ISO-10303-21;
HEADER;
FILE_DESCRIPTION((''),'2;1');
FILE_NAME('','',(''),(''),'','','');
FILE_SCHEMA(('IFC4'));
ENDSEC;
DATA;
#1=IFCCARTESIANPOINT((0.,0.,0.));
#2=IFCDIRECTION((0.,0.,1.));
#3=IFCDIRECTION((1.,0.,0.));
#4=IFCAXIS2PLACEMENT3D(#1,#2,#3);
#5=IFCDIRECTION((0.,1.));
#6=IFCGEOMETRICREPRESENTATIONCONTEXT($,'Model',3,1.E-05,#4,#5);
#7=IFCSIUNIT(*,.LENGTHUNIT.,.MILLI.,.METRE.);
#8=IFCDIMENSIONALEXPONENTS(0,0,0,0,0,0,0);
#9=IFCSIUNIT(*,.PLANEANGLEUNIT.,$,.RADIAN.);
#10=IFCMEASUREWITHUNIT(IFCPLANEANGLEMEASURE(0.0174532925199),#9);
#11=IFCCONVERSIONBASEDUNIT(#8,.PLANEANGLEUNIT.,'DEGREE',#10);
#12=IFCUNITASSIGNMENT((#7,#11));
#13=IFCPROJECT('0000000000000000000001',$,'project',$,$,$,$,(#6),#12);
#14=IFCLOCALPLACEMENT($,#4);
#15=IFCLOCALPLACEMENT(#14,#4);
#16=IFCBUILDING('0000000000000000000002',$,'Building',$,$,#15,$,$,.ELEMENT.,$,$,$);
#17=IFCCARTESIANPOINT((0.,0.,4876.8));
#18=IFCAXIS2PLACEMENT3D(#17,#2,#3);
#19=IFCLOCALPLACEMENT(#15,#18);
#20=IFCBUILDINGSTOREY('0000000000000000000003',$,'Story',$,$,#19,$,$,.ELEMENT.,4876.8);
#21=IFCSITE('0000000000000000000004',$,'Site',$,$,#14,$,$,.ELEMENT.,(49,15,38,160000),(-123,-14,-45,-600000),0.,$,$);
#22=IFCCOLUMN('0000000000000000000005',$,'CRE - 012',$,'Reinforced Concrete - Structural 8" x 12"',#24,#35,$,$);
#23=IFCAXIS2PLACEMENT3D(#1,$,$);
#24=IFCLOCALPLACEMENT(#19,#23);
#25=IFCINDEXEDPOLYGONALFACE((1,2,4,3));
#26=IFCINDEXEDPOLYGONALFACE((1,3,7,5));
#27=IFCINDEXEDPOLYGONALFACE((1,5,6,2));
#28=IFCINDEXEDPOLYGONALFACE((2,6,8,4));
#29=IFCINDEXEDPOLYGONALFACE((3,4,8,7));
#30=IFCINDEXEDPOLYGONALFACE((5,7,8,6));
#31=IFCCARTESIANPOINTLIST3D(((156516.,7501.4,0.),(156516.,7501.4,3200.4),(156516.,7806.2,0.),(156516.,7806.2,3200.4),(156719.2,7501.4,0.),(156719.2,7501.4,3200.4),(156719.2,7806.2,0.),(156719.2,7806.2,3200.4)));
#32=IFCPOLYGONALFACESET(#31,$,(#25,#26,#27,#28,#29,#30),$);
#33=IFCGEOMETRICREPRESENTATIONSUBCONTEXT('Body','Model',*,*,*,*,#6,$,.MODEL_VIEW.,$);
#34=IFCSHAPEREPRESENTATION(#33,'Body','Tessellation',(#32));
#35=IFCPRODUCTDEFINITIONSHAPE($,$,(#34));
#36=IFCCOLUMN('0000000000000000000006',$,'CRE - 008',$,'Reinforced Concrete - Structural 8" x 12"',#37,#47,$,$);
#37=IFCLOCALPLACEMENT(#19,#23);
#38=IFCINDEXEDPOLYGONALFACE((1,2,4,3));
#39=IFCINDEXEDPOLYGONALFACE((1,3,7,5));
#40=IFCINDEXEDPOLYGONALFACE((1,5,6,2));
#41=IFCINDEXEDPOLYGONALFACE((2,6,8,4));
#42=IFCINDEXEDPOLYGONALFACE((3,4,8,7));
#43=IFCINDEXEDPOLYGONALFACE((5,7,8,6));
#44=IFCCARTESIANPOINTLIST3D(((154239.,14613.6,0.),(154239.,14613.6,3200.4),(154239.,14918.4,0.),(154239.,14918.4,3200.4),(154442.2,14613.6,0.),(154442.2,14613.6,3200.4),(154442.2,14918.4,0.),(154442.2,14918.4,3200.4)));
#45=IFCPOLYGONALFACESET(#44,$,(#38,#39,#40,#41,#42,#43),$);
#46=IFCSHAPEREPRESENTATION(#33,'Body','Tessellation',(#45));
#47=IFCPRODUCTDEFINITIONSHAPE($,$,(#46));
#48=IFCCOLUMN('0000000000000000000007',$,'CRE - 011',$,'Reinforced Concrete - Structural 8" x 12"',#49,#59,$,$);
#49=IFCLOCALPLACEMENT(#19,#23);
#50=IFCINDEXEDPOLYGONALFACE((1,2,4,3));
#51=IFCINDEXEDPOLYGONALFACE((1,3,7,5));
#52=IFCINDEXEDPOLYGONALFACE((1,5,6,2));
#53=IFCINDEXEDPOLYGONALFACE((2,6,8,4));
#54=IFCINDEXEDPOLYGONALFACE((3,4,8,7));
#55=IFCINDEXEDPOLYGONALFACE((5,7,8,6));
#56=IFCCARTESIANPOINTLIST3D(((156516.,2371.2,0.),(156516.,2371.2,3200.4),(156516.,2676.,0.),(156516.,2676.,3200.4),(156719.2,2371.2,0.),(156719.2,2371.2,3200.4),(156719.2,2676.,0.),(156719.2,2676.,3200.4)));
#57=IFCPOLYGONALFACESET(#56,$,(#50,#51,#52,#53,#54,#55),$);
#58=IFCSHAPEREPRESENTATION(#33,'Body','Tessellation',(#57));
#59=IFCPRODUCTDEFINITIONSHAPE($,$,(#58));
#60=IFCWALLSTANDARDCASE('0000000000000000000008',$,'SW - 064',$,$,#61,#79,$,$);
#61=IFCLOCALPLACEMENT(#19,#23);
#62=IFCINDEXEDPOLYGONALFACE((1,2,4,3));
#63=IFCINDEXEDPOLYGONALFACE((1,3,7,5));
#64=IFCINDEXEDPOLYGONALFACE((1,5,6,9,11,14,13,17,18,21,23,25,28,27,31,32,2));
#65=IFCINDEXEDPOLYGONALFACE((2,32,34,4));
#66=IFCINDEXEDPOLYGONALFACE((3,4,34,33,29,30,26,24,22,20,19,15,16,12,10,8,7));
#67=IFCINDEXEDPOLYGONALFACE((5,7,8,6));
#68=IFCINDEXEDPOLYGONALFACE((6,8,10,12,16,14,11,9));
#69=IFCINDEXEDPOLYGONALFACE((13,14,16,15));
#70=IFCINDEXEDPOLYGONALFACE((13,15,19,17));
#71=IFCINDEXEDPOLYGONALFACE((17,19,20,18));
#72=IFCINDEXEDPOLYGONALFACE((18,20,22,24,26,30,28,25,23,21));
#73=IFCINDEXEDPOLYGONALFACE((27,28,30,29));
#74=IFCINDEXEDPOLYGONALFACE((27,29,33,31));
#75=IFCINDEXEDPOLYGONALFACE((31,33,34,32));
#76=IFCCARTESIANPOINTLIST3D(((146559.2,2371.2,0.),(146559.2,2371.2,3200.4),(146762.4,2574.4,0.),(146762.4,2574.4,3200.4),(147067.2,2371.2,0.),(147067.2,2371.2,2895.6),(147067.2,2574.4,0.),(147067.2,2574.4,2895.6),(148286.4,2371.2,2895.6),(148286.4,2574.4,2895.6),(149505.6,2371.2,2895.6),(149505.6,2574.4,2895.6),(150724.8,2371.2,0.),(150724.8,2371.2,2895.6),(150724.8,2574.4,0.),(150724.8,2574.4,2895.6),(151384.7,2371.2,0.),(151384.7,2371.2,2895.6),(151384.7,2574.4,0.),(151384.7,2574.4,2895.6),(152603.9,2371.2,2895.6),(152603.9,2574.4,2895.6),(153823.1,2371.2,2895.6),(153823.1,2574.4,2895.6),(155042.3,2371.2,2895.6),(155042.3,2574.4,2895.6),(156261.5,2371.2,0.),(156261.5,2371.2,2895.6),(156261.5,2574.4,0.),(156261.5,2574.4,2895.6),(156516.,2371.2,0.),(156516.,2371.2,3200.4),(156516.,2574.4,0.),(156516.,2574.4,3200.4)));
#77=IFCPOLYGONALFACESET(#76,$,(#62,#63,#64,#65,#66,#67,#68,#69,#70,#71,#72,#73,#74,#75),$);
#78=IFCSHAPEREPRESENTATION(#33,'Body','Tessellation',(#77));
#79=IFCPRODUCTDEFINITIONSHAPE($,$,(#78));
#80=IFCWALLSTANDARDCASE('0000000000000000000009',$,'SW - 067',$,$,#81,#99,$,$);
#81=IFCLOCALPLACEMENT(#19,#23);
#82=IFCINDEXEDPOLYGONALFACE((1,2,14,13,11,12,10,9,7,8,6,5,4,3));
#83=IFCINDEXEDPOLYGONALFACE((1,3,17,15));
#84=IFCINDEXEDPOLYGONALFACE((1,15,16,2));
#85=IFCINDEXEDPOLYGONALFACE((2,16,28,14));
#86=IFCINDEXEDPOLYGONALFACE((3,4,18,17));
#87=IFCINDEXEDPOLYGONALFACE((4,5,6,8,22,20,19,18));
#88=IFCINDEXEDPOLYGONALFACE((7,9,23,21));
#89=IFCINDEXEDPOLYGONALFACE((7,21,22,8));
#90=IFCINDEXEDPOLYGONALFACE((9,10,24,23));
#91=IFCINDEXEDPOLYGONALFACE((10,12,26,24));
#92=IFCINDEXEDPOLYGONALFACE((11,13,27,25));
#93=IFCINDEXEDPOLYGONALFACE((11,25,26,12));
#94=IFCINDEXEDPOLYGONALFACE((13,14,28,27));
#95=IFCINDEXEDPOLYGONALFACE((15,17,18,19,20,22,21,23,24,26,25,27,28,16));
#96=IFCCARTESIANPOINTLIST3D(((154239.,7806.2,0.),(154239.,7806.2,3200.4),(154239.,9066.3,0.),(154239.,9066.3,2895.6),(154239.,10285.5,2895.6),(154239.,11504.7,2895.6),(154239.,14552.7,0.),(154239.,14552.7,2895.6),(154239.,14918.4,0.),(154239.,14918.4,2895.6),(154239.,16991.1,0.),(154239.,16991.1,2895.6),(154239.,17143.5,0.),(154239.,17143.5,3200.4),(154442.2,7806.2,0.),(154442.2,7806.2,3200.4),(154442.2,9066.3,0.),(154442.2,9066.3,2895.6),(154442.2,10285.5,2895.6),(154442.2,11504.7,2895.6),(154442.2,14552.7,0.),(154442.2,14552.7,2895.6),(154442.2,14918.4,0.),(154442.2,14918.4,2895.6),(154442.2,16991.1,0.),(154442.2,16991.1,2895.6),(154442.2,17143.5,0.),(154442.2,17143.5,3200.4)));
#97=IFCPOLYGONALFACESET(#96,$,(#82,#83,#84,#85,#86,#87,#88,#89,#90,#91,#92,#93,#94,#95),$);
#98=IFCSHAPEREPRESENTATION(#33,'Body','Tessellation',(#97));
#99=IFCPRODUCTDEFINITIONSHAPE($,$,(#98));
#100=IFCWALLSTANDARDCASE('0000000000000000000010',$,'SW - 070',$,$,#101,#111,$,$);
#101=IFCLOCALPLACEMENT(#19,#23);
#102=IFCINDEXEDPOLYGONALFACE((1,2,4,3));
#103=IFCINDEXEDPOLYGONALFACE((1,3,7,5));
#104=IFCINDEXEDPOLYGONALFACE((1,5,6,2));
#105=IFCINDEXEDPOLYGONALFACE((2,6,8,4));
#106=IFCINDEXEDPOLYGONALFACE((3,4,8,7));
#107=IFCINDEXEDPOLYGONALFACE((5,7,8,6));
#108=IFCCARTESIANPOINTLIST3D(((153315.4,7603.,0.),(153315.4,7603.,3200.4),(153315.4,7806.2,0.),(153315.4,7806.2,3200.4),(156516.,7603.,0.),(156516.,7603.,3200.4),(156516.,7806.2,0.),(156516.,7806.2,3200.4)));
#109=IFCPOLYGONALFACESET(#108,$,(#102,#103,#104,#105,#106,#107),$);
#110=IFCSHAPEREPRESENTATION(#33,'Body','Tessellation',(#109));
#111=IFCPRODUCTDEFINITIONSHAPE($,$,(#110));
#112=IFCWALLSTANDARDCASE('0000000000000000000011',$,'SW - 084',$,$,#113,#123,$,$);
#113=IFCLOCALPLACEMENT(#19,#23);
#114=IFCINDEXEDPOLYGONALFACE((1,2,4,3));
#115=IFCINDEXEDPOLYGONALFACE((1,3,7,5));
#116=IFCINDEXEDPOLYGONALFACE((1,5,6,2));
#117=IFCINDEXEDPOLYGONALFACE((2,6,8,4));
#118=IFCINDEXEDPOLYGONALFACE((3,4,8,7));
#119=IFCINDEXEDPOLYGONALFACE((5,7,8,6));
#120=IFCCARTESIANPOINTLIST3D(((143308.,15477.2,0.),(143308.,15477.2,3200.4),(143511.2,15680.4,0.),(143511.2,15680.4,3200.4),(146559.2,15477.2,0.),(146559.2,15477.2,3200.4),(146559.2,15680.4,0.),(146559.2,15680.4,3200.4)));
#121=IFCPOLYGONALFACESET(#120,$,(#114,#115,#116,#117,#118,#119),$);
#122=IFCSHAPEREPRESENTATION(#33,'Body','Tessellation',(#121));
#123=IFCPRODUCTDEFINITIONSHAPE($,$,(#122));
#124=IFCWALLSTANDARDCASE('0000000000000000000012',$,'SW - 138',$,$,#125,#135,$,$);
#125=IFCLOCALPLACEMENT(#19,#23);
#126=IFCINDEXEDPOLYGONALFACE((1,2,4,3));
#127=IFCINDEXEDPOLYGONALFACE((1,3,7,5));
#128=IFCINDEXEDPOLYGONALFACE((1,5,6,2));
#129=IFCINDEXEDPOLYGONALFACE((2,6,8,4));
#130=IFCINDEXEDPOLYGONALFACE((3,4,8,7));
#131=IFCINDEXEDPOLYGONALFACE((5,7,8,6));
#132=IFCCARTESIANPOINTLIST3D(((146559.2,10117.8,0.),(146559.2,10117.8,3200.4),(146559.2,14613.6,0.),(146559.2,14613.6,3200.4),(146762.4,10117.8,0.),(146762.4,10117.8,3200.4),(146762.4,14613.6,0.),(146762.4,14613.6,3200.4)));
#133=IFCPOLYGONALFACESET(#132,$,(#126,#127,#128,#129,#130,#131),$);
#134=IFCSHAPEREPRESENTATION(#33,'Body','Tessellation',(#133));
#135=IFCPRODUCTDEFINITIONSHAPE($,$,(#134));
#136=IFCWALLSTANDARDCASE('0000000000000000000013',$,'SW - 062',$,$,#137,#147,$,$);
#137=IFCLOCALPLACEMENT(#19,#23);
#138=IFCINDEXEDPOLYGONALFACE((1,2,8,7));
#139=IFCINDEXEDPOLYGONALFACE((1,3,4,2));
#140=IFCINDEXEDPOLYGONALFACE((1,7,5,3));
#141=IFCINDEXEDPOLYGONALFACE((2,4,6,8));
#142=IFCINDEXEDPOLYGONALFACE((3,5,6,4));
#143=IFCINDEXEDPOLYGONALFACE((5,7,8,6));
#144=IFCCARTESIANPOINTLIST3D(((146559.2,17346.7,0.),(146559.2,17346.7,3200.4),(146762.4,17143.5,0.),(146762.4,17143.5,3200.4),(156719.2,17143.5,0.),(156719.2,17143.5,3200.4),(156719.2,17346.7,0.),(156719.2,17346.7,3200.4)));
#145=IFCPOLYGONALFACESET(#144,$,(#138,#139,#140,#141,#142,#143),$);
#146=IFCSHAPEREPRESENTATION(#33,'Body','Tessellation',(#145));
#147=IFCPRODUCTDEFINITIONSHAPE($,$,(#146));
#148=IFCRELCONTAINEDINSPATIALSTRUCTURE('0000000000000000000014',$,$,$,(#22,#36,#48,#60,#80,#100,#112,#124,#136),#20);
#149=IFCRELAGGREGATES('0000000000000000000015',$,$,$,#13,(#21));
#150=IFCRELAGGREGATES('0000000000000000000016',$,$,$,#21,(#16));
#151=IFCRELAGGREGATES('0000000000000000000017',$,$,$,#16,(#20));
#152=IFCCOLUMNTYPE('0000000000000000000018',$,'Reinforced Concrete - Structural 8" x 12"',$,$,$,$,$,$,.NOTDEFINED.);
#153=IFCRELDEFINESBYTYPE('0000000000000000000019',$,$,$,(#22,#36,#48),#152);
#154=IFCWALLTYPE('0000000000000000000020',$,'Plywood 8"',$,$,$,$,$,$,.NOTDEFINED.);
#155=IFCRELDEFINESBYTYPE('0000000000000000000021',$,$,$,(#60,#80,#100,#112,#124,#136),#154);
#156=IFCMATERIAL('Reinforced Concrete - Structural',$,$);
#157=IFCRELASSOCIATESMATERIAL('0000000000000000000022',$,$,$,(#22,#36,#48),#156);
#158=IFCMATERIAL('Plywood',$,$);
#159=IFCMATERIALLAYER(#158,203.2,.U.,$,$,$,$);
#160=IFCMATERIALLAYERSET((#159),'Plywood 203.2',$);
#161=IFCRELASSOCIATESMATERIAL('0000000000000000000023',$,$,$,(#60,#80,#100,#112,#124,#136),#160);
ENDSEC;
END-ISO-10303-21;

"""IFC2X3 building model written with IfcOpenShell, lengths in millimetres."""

from ifc_helpers import new_model, entity, si_unit, converted_unit, direction, frame, origin_with_axes, origin_2d_with_axis, place, context, subcontext, project, spatial, polyline, rectangle, outline, extrude, material, layer, layer_set, layer_usage, type_object, element, save


model = new_model("IFC2X3")

# Units and contexts
model_context = context("Model", 3, precision=1e-05, world=origin_with_axes(), true_north=direction((0.0, 1.0)))
body_context = subcontext(model_context, "Body", "Model", "MODEL_VIEW")
ifc_project = project(units=[si_unit("LENGTHUNIT", "METRE", prefix="MILLI"), converted_unit("PLANEANGLEUNIT", "DEGREE", entity("IfcPlaneAngleMeasure", 0.0174532925199), si_unit("PLANEANGLEUNIT", "RADIAN"), dimensions=[0, 0, 0, 0, 0, 0, 0])], contexts=[model_context])

# Site, building, storey
site_placement = place(None, origin_with_axes())
site = spatial("IfcSite", under=ifc_project, at=site_placement, Name="Site", CompositionType="ELEMENT", RefLatitude=(49, 15, 38, 160000), RefLongitude=(-123, -14, -45, -600000), RefElevation=0.0)
building_placement = place(site_placement, origin_with_axes())
building = spatial("IfcBuilding", under=site, at=building_placement, Name="Building", CompositionType="ELEMENT")
storey_placement = place(building_placement, frame((0.0, 0.0, 4876.8), z_axis=(0.0, 0.0, 1.0), x_axis=(1.0, 0.0, 0.0)))
storey = spatial("IfcBuildingStorey", under=building, at=storey_placement, Name="Story", CompositionType="ELEMENT", Elevation=4876.8)

# Columns
ifc_material_1 = material(Name="Reinforced Concrete - Structural")
column_type = type_object("IfcColumnType", Name="Reinforced Concrete - Structural 8\" x 12\"", PredefinedType="NOTDEFINED")
for number, where, z_axis, x_axis, name in (
    (1, (156617.6, 7653.8, 0.0), (0.0, 0.0, 1.0), (1.0, 0.0, 0.0), "CRE - 012"),
    (2, (154340.6, 14766.0, 0.0), (0.0, 0.0, 1.0), (1.0, 0.0, 0.0), "CRE - 008"),
    (3, (156617.6, 2523.6, 0.0), (0.0, 0.0, 1.0), (1.0, 0.0, 0.0), "CRE - 011"),
):
    element("IfcColumn", number, at=place(storey_placement, frame(where, z_axis=z_axis, x_axis=x_axis)), inside=storey, type_object=column_type, material=ifc_material_1, Name=name, ObjectType="Reinforced Concrete - Structural 8\" x 12\"", context=body_context, shape_type="SweptSolid", body=[
        extrude(rectangle(XDim=203.2, YDim=304.8, at=origin_2d_with_axis()), origin_with_axes(), (0.0, 0.0, 1.0), 3200.4),
    ])

# Walls, openings
ifc_material_2 = material(Name="Plywood")
ifc_layer_1 = layer(ifc_material_2, 203.2, ventilated="UNKNOWN")
ifc_layer_set_1 = layer_set([ifc_layer_1], Name="Plywood 203.2")
ifc_layer_usage_1 = layer_usage(ifc_layer_set_1, "AXIS2", "POSITIVE", 0.0)
wall_type_1 = type_object("IfcWallType", Name="Plywood 8\"", PredefinedType="NOTDEFINED")
wall_1_placement = place(storey_placement, frame((156516.0, 2574.4, 0.0), z_axis=(0.0, 0.0, 1.0), x_axis=(-1.0, 0.0, 0.0)))
wall_1 = element("IfcWallStandardCase", 4, at=wall_1_placement, inside=storey, type_object=wall_type_1, material=ifc_layer_usage_1, Name="SW - 064", context=body_context, shape_type="SweptSolid", body=[
    extrude(outline(polyline([(0.0, 0.0), (9753.6, 0.0), (9956.8, 203.2), (0.0, 203.2), (0.0, 0.0)])), origin_with_axes(), (0.0, 0.0, 1.0), 3200.4),
])
opening_1_placement = place(wall_1_placement, frame((864.2, 0.0, 0.0), z_axis=(0.0, 0.0, 1.0), x_axis=(1.0, 0.0, 0.0)))
element("IfcOpeningElement", 5, at=opening_1_placement, cuts=wall_1, context=body_context, shape_type="SweptSolid", body=[
    extrude(rectangle(XDim=1219.2, YDim=2895.6, at=origin_2d_with_axis()), frame((0.0, -203.2, 1447.8), z_axis=(0.0, -1.0, 0.0), x_axis=(-1.0, 0.0, 0.0)), (0.0, 0.0, -1.0), 609.6),
])
opening_2_placement = place(wall_1_placement, frame((2083.4, 0.0, 0.0), z_axis=(0.0, 0.0, 1.0), x_axis=(1.0, 0.0, 0.0)))
element("IfcOpeningElement", 6, at=opening_2_placement, cuts=wall_1, context=body_context, shape_type="SweptSolid", body=[
    extrude(rectangle(XDim=1219.2, YDim=2895.6, at=origin_2d_with_axis()), frame((0.0, -203.2, 1447.8), z_axis=(0.0, 1.0, 0.0), x_axis=(1.0, 0.0, 0.0)), (0.0, 0.0, 1.0), 609.6),
])
opening_3_placement = place(wall_1_placement, frame((3302.6, 0.0, 0.0), z_axis=(0.0, 0.0, 1.0), x_axis=(1.0, 0.0, 0.0)))
element("IfcOpeningElement", 7, at=opening_3_placement, cuts=wall_1, context=body_context, shape_type="SweptSolid", body=[
    extrude(rectangle(XDim=1219.2, YDim=2895.6, at=origin_2d_with_axis()), frame((0.0, -203.2, 1447.8), z_axis=(0.0, 1.0, 0.0), x_axis=(1.0, 0.0, 0.0)), (0.0, 0.0, 1.0), 609.6),
])
opening_4_placement = place(wall_1_placement, frame((4521.8, 0.0, 0.0), z_axis=(0.0, 0.0, 1.0), x_axis=(1.0, 0.0, 0.0)))
element("IfcOpeningElement", 8, at=opening_4_placement, cuts=wall_1, context=body_context, shape_type="SweptSolid", body=[
    extrude(rectangle(XDim=1219.2, YDim=2895.6, at=origin_2d_with_axis()), frame((0.0, -203.2, 1447.8), z_axis=(0.0, -1.0, 0.0), x_axis=(-1.0, 0.0, 0.0)), (0.0, 0.0, -1.0), 609.6),
])
opening_5_placement = place(wall_1_placement, frame((6400.8, 0.0, 0.0), z_axis=(0.0, 0.0, 1.0), x_axis=(1.0, 0.0, 0.0)))
element("IfcOpeningElement", 9, at=opening_5_placement, cuts=wall_1, context=body_context, shape_type="SweptSolid", body=[
    extrude(rectangle(XDim=1219.2, YDim=2895.6, at=origin_2d_with_axis()), frame((0.0, -203.2, 1447.8), z_axis=(0.0, 1.0, 0.0), x_axis=(1.0, 0.0, 0.0)), (0.0, 0.0, 1.0), 609.6),
])
opening_6_placement = place(wall_1_placement, frame((7620.0, 0.0, 0.0), z_axis=(0.0, 0.0, 1.0), x_axis=(1.0, 0.0, 0.0)))
element("IfcOpeningElement", 10, at=opening_6_placement, cuts=wall_1, context=body_context, shape_type="SweptSolid", body=[
    extrude(rectangle(XDim=1219.2, YDim=2895.6, at=origin_2d_with_axis()), frame((0.0, -203.2, 1447.8), z_axis=(0.0, -1.0, 0.0), x_axis=(-1.0, 0.0, 0.0)), (0.0, 0.0, -1.0), 609.6),
])
opening_7_placement = place(wall_1_placement, frame((8839.2, 0.0, 0.0), z_axis=(0.0, 0.0, 1.0), x_axis=(1.0, 0.0, 0.0)))
element("IfcOpeningElement", 11, at=opening_7_placement, cuts=wall_1, context=body_context, shape_type="SweptSolid", body=[
    extrude(rectangle(XDim=1219.2, YDim=2895.6, at=origin_2d_with_axis()), frame((0.0, -203.2, 1447.8), z_axis=(0.0, 1.0, 0.0), x_axis=(1.0, 0.0, 0.0)), (0.0, 0.0, 1.0), 609.6),
])
ifc_layer_usage_2 = layer_usage(ifc_layer_set_1, "AXIS2", "NEGATIVE", 0.0)
wall_2_placement = place(storey_placement, frame((154239.0, 7603.0, 0.0), z_axis=(0.0, 0.0, 1.0), x_axis=(0.0, 1.0, 0.0)))
wall_2 = element("IfcWallStandardCase", 12, at=wall_2_placement, inside=storey, type_object=wall_type_1, material=ifc_layer_usage_2, Name="SW - 067", context=body_context, shape_type="SweptSolid", body=[
    extrude(outline(polyline([(203.2, -203.2), (9540.4, -203.2), (9540.4, 0.0), (203.2, 0.0), (203.2, -203.2)])), origin_with_axes(), (0.0, 0.0, 1.0), 3200.4),
])
opening_8_placement = place(wall_2_placement, frame((8351.7, 0.0, 0.0), z_axis=(0.0, 0.0, 1.0), x_axis=(1.0, 0.0, 0.0)))
element("IfcOpeningElement", 13, at=opening_8_placement, cuts=wall_2, context=body_context, shape_type="SweptSolid", body=[
    extrude(rectangle(XDim=2072.6, YDim=2895.6, at=origin_2d_with_axis()), frame((0.0, 203.2, 1447.8), z_axis=(0.0, -1.0, 0.0), x_axis=(-1.0, 0.0, 0.0)), (0.0, 0.0, 1.0), 609.6),
])
opening_9_placement = place(wall_2_placement, frame((2072.8, 0.0, 0.0), z_axis=(0.0, 0.0, 1.0), x_axis=(1.0, 0.0, 0.0)))
element("IfcOpeningElement", 14, at=opening_9_placement, cuts=wall_2, context=body_context, shape_type="SweptSolid", body=[
    extrude(rectangle(XDim=1219.2, YDim=2895.6, at=origin_2d_with_axis()), frame((0.0, 203.2, 1447.8), z_axis=(0.0, 1.0, 0.0), x_axis=(1.0, 0.0, 0.0)), (0.0, 0.0, -1.0), 609.6),
])
opening_10_placement = place(wall_2_placement, frame((3292.0, 0.0, 0.0), z_axis=(0.0, 0.0, 1.0), x_axis=(1.0, 0.0, 0.0)))
element("IfcOpeningElement", 15, at=opening_10_placement, cuts=wall_2, context=body_context, shape_type="SweptSolid", body=[
    extrude(rectangle(XDim=1219.2, YDim=2895.6, at=origin_2d_with_axis()), frame((0.0, 203.2, 1447.8), z_axis=(0.0, -1.0, 0.0), x_axis=(-1.0, 0.0, 0.0)), (0.0, 0.0, 1.0), 609.6),
])
opening_11_placement = place(wall_2_placement, frame((5425.6, 0.0, 0.0), z_axis=(0.0, 0.0, 1.0), x_axis=(1.0, 0.0, 0.0)))
element("IfcOpeningElement", 16, at=opening_11_placement, cuts=wall_2, context=body_context, shape_type="SweptSolid", body=[
    extrude(rectangle(XDim=3048.0, YDim=2895.6, at=origin_2d_with_axis()), frame((0.0, 203.2, 1447.8), z_axis=(0.0, -1.0, 0.0), x_axis=(-1.0, 0.0, 0.0)), (0.0, 0.0, 1.0), 609.6),
])

# Walls
ifc_layer_usage_3 = layer_usage(ifc_layer_set_1, "AXIS2", "POSITIVE", 0.0)
wall_3_placement = place(storey_placement, frame((153315.4, 7603.0, 0.0), z_axis=(0.0, 0.0, 1.0), x_axis=(1.0, 0.0, 0.0)))
element("IfcWallStandardCase", 17, at=wall_3_placement, inside=storey, type_object=wall_type_1, material=ifc_layer_usage_3, Name="SW - 070", context=body_context, shape_type="SweptSolid", body=[
    extrude(outline(polyline([(0.0, 0.0), (3200.6, 0.0), (3200.6, 203.2), (0.0, 203.2), (0.0, 0.0)])), origin_with_axes(), (0.0, 0.0, 1.0), 3200.4),
])
ifc_layer_usage_4 = layer_usage(ifc_layer_set_1, "AXIS2", "NEGATIVE", 0.0)
wall_4_placement = place(storey_placement, frame((146762.4, 15477.2, 0.0), z_axis=(0.0, 0.0, 1.0), x_axis=(-1.0, 0.0, 0.0)))
element("IfcWallStandardCase", 18, at=wall_4_placement, inside=storey, type_object=wall_type_1, material=ifc_layer_usage_4, Name="SW - 084", context=body_context, shape_type="SweptSolid", body=[
    extrude(outline(polyline([(203.2, -203.2), (3251.2, -203.2), (3454.4, 0.0), (203.2, 0.0), (203.2, -203.2)])), origin_with_axes(), (0.0, 0.0, 1.0), 3200.4),
])
ifc_layer_usage_5 = layer_usage(ifc_layer_set_1, "AXIS2", "NEGATIVE", 0.0)
wall_5_placement = place(storey_placement, frame((146762.4, 14613.6, 0.0), z_axis=(0.0, 0.0, 1.0), x_axis=(0.0, -1.0, 0.0)))
element("IfcWallStandardCase", 19, at=wall_5_placement, inside=storey, type_object=wall_type_1, material=ifc_layer_usage_5, Name="SW - 138", context=body_context, shape_type="SweptSolid", body=[
    extrude(outline(polyline([(0.0, -203.2), (4495.8, -203.2), (4495.8, 0.0), (0.0, 0.0), (0.0, -203.2)])), origin_with_axes(), (0.0, 0.0, 1.0), 3200.4),
])
ifc_layer_usage_6 = layer_usage(ifc_layer_set_1, "AXIS2", "POSITIVE", 0.0)
wall_6_placement = place(storey_placement, frame((146762.4, 17143.5, 0.0), z_axis=(0.0, 0.0, 1.0), x_axis=(1.0, 0.0, 0.0)))
element("IfcWallStandardCase", 20, at=wall_6_placement, inside=storey, type_object=wall_type_1, material=ifc_layer_usage_6, Name="SW - 062", context=body_context, shape_type="SweptSolid", body=[
    extrude(outline(polyline([(0.0, 0.0), (9956.8, 0.0), (9956.8, 203.2), (-203.2, 203.2), (0.0, 0.0)])), origin_with_axes(), (0.0, 0.0, 1.0), 3200.4),
])

save(model, "model.ifc")
